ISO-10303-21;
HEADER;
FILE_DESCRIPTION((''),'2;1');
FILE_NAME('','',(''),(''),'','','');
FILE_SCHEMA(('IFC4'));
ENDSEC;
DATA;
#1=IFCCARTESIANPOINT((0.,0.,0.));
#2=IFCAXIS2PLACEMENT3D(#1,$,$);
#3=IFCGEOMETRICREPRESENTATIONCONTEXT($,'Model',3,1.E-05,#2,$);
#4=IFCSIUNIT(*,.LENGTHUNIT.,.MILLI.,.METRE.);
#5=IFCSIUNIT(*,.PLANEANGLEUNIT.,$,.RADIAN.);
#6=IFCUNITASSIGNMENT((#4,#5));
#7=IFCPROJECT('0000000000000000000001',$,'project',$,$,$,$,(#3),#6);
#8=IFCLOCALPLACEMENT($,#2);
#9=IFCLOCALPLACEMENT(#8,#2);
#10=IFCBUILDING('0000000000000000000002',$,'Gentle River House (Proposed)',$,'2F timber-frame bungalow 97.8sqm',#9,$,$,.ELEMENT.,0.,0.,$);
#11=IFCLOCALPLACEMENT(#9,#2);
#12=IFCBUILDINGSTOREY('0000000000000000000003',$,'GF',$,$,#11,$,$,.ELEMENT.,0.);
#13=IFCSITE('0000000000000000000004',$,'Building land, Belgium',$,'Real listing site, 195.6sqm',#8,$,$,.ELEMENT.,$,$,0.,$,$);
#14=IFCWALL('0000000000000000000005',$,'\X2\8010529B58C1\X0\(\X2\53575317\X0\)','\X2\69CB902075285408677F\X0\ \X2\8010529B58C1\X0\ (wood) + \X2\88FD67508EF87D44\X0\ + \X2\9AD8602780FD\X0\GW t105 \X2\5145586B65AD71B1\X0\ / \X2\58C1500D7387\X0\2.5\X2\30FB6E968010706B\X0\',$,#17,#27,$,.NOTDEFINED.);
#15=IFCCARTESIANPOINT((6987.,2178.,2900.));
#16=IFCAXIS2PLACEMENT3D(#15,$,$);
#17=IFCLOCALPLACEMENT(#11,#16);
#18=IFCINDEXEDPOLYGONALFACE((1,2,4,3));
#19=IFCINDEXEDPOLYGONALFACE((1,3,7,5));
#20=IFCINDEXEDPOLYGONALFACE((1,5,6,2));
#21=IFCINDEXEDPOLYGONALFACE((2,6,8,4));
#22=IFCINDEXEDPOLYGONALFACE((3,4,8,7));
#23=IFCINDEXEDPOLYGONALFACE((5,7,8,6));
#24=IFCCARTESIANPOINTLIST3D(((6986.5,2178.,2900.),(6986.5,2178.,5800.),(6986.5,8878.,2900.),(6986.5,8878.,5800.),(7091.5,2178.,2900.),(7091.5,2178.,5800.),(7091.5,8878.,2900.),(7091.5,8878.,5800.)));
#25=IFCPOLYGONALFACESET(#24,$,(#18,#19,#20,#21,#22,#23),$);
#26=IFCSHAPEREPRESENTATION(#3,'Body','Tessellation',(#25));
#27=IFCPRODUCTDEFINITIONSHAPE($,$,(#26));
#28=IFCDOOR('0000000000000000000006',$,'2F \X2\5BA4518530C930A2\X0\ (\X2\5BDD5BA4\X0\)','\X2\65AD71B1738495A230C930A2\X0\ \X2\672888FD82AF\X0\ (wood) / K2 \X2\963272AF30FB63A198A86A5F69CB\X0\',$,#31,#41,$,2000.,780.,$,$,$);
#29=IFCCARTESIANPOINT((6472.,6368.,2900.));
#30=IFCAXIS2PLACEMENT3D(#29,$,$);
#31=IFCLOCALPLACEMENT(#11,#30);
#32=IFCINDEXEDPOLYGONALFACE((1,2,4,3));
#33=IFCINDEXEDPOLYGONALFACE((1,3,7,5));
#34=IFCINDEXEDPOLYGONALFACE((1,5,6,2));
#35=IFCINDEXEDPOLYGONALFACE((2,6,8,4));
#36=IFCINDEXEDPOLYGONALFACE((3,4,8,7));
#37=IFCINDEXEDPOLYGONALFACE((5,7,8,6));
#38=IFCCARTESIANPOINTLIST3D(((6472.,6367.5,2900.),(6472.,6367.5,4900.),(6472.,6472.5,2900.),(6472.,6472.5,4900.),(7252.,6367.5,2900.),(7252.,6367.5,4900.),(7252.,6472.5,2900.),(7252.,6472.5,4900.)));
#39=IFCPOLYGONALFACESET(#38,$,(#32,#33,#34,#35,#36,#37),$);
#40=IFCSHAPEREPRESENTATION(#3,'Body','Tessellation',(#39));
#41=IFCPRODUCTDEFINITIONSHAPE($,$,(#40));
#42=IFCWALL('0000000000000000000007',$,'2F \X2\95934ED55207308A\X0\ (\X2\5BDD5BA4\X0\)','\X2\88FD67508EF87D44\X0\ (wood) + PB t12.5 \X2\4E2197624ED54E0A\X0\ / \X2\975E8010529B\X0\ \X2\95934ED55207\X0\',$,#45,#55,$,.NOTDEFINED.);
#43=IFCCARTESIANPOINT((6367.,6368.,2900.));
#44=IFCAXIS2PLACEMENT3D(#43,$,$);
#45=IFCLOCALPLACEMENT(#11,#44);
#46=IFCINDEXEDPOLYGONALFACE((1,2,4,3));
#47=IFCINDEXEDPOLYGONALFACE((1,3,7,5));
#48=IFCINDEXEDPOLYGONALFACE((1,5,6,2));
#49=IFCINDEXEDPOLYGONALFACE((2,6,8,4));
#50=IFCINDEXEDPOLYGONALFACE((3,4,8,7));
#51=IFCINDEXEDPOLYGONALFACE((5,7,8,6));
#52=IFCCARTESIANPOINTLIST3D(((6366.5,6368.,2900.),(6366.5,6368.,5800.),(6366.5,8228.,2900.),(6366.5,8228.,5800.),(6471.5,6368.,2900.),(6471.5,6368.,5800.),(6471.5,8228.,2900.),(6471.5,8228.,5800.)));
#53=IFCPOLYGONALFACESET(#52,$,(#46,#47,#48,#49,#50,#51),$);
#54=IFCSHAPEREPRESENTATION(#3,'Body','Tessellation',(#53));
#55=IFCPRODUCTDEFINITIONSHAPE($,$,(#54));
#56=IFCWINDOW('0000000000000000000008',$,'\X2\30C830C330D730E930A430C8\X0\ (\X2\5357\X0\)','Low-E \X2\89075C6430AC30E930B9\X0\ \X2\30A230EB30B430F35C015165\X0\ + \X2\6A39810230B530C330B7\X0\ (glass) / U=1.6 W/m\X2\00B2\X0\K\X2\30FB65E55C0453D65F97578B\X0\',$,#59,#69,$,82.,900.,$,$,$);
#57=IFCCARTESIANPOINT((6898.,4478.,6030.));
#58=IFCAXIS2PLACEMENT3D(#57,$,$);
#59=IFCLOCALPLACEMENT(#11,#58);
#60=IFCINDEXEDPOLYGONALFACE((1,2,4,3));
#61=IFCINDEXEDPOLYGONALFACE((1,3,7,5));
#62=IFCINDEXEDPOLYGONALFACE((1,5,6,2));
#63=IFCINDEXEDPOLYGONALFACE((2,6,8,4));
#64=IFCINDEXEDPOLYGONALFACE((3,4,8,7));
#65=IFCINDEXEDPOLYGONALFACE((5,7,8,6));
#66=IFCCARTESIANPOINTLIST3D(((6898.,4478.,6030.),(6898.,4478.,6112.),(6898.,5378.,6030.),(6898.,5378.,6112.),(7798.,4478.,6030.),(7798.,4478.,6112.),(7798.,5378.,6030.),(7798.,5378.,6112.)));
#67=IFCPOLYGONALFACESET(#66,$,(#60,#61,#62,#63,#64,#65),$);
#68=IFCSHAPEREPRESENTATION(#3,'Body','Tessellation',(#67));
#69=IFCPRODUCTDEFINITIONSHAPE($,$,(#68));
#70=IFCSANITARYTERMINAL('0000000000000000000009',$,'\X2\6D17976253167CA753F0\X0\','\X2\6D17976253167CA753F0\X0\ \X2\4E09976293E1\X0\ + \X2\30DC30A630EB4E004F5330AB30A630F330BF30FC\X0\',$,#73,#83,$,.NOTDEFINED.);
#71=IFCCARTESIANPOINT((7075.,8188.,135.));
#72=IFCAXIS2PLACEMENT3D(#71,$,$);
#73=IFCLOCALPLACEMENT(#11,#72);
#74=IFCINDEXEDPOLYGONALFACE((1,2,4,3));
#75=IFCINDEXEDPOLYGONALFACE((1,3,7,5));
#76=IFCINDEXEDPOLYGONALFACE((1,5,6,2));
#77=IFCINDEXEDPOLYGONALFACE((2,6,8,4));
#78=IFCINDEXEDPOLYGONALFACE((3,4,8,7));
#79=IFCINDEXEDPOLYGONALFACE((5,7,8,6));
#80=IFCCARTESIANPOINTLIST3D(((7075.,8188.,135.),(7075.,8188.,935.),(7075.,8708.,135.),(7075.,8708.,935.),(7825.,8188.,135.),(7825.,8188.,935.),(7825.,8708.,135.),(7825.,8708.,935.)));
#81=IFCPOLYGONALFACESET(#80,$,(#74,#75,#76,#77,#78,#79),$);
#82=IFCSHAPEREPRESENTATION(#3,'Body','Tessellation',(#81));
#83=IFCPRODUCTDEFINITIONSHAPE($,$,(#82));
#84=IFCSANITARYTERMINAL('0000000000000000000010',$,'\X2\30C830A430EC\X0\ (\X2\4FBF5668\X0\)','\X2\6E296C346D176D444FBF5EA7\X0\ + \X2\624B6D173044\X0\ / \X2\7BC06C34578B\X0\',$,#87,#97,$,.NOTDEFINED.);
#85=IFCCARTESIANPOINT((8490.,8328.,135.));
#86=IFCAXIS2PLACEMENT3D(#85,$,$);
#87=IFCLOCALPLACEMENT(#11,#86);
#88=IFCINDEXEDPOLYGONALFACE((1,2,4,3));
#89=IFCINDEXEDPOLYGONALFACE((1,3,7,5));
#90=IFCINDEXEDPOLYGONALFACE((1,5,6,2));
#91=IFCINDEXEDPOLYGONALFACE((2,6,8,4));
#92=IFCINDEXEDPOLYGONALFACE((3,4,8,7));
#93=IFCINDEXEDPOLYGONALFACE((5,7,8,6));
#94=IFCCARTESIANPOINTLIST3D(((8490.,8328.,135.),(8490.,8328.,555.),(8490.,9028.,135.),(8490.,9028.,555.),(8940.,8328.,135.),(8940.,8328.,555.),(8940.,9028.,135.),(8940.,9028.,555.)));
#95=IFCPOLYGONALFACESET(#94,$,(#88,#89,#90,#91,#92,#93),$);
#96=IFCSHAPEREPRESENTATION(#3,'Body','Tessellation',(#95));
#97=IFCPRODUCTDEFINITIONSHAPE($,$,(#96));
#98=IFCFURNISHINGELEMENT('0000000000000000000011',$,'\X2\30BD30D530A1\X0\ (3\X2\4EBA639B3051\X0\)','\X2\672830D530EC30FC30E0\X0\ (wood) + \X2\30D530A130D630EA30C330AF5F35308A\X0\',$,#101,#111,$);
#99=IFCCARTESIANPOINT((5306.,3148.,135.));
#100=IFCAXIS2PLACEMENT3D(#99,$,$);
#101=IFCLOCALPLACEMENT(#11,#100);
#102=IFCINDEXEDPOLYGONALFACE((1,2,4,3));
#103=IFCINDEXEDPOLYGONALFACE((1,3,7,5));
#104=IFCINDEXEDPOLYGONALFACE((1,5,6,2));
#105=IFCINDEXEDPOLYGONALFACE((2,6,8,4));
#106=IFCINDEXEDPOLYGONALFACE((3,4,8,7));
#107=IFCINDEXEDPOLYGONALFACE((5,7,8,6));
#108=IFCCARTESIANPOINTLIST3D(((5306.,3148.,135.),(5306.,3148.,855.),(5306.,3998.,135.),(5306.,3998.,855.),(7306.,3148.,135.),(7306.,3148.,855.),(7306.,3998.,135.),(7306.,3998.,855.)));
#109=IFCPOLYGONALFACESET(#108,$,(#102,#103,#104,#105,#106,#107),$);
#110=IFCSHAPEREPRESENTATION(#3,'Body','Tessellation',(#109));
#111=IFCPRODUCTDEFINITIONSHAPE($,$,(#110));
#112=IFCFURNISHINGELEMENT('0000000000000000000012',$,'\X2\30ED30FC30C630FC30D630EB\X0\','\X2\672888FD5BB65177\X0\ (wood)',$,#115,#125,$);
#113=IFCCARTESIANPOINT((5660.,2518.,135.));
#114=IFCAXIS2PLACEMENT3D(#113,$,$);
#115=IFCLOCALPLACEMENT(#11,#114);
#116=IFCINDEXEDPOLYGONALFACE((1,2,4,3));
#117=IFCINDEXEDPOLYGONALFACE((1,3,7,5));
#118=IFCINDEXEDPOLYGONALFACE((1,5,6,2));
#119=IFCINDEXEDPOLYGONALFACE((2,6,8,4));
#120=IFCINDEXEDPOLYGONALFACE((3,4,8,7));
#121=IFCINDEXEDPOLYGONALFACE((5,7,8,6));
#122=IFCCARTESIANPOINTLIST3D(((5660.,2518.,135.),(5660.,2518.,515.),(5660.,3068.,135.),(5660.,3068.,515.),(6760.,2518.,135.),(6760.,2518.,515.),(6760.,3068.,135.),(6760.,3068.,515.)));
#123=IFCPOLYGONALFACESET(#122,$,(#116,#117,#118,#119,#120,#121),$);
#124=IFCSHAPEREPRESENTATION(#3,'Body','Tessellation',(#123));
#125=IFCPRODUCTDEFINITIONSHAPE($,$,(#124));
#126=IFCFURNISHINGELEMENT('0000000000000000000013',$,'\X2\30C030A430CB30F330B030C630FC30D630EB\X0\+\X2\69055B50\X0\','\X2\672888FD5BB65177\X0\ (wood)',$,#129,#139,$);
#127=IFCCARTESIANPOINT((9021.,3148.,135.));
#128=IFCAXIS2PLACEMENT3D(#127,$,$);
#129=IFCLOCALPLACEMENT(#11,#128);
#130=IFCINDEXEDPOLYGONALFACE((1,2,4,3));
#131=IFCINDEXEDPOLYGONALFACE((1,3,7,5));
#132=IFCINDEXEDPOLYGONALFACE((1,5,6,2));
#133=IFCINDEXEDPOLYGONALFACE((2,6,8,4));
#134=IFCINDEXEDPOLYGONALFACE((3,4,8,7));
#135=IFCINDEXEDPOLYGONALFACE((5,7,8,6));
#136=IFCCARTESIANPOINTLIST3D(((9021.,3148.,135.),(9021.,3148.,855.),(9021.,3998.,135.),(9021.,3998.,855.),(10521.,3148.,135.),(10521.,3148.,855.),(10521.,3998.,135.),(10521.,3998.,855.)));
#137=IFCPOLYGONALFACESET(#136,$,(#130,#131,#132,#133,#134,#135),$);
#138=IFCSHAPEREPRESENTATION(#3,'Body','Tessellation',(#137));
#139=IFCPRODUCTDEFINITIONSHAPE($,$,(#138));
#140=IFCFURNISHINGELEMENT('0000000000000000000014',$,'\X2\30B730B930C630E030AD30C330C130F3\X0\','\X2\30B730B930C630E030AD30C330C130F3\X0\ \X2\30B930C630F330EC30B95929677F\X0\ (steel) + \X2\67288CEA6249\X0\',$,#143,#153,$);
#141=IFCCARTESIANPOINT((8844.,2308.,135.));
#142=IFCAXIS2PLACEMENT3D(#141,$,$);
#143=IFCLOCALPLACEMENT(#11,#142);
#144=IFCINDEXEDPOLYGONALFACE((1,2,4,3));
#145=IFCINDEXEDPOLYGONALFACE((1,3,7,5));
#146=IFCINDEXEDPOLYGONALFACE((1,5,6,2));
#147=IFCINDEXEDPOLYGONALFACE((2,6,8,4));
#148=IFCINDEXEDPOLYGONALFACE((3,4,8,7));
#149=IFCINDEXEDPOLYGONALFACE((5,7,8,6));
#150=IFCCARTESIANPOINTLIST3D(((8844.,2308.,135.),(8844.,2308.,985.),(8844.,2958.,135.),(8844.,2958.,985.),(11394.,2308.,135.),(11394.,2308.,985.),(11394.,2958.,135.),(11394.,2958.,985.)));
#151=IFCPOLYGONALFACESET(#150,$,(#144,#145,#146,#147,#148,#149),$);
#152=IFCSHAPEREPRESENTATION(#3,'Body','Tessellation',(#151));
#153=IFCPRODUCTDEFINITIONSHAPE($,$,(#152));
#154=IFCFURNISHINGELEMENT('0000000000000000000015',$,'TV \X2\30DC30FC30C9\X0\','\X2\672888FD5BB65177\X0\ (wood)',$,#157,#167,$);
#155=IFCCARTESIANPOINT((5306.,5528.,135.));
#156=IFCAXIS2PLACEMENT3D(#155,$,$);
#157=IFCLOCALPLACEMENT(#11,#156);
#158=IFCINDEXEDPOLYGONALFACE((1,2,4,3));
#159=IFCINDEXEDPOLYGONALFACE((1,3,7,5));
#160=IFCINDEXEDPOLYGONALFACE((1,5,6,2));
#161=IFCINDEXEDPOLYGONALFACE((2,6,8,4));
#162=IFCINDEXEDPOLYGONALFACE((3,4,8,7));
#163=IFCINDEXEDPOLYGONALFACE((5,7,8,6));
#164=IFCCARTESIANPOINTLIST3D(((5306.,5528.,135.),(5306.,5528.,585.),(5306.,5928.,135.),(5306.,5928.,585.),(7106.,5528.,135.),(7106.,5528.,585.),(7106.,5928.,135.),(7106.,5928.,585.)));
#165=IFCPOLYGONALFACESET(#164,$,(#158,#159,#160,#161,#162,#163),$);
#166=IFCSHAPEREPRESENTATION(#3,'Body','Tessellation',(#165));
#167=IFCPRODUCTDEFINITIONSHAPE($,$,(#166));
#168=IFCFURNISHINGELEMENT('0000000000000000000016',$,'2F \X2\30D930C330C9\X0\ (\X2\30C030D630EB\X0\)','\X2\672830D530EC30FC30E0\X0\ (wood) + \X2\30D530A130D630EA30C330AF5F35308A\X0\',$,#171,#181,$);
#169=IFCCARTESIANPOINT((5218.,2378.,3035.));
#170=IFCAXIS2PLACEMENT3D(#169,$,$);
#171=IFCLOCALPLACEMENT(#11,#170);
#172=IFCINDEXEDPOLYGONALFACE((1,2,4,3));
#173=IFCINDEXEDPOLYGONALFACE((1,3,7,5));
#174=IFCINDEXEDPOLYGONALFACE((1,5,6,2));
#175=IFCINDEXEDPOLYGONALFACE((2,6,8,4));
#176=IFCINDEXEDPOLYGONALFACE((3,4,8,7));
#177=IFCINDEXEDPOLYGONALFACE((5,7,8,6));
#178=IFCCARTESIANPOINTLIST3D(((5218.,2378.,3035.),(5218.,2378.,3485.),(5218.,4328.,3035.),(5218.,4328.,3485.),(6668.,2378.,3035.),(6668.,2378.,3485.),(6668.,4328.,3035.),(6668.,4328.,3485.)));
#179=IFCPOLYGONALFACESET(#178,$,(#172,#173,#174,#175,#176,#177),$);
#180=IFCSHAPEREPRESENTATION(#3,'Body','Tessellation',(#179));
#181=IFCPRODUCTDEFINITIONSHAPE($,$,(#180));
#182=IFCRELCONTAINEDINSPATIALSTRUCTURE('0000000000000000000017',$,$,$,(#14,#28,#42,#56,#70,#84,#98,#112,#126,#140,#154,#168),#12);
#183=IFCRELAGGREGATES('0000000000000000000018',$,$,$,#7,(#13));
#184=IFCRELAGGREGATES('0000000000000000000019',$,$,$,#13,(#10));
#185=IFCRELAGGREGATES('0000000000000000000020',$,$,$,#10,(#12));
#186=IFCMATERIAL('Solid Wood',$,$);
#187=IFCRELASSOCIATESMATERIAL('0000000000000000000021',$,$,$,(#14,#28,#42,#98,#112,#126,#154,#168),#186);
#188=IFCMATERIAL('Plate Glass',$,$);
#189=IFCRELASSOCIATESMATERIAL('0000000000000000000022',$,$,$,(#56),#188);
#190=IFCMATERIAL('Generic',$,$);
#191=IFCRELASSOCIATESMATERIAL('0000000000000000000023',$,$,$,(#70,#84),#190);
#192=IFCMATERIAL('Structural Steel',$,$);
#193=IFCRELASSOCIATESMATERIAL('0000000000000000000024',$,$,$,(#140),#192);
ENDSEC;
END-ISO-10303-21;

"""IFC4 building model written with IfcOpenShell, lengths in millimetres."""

from ifc_helpers import new_model, si_unit, frame, frame_2d, origin, place, context, project, spatial, rectangle, extrude, material, element, fill, save


model = new_model("IFC4")

# Units and contexts
model_context = context("Model", 3, precision=1e-05, world=origin())
ifc_project = project(units=[si_unit("LENGTHUNIT", "METRE", prefix="MILLI"), si_unit("PLANEANGLEUNIT", "RADIAN")], contexts=[model_context])

# Site, building, storey
site_placement = place(None, origin())
site = spatial("IfcSite", under=ifc_project, at=site_placement, Name="Building land, Belgium", ObjectType="Real listing site, 195.6sqm", CompositionType="ELEMENT", RefElevation=0.0)
building_placement = place(site_placement, origin())
building = spatial("IfcBuilding", under=site, at=building_placement, Name="Gentle River House (Proposed)", ObjectType="2F timber-frame bungalow 97.8sqm", CompositionType="ELEMENT", ElevationOfRefHeight=0.0, ElevationOfTerrain=0.0)
storey_placement = place(building_placement, origin())
storey = spatial("IfcBuildingStorey", under=building, at=storey_placement, Name="GF", CompositionType="ELEMENT", Elevation=0.0)

# Shared definitions
ifc_material_1 = material(Name="Solid Wood")

# Wall, opening, door
wall_1_placement = place(storey_placement, frame((6987.0, 2178.0, 2900.0)))
wall_1 = element("IfcWall", 1, at=wall_1_placement, inside=storey, material=ifc_material_1, Name="耐力壁(南北)", Description="構造用合板 耐力壁 (wood) + 製材軸組 + 高性能GW t105 充填断熱 / 壁倍率2.5・準耐火", PredefinedType="NOTDEFINED", context=model_context, shape_type="SweptSolid", body=[
    extrude(rectangle(XDim=105.0, YDim=6700.0, at=frame_2d((52.0, 3350.0))), frame((6987.0, 2178.0, 2900.0)), (0.0, 0.0, 1.0), 2900.0),
])
opening_1_placement = place(storey_placement, frame((6472.0, 6368.0, 2900.0)))
opening_1 = element("IfcOpeningElement", 2, at=opening_1_placement, cuts=wall_1, PredefinedType="NOTDEFINED", context=model_context, shape_type="SweptSolid", body=[
    extrude(rectangle(XDim=780.0, YDim=105.0, at=frame_2d((390.0, 52.0))), frame((6472.0, 6368.0, 2900.0)), (0.0, 0.0, 1.0), 2000.0),
])
door_1_placement = place(storey_placement, frame((6472.0, 6368.0, 2900.0)))
door_1 = element("IfcDoor", 3, at=door_1_placement, inside=storey, material=ifc_material_1, Name="2F 室内ドア (寝室)", Description="断熱玄関ドア 木製芯 (wood) / K2 防犯・採風機構", OverallHeight=2000.0, OverallWidth=780.0, context=model_context, shape_type="SweptSolid", body=[
    extrude(rectangle(XDim=780.0, YDim=105.0, at=frame_2d((390.0, 52.0))), frame((6472.0, 6368.0, 2900.0)), (0.0, 0.0, 1.0), 2000.0),
])
fill(opening_1, door_1)

# Wall
wall_2_placement = place(storey_placement, frame((6367.0, 6368.0, 2900.0)))
element("IfcWall", 4, at=wall_2_placement, inside=storey, material=ifc_material_1, Name="2F 間仕切り (寝室)", Description="製材軸組 (wood) + PB t12.5 両面仕上 / 非耐力 間仕切", PredefinedType="NOTDEFINED", context=model_context, shape_type="SweptSolid", body=[
    extrude(rectangle(XDim=105.0, YDim=1860.0, at=frame_2d((52.0, 930.0))), frame((6367.0, 6368.0, 2900.0)), (0.0, 0.0, 1.0), 2900.0),
])

# Window
ifc_material_2 = material(Name="Plate Glass")
window_placement = place(storey_placement, frame((6898.0, 4478.0, 6030.0)))
element("IfcWindow", 5, at=window_placement, inside=storey, material=ifc_material_2, Name="トップライト (南)", Description="Low-E 複層ガラス アルゴン封入 + 樹脂サッシ (glass) / U=1.6 W/m²K・日射取得型", OverallHeight=82.0, OverallWidth=900.0, context=model_context, shape_type="SweptSolid", body=[
    extrude(rectangle(XDim=900.0, YDim=900.0, at=frame_2d((450.0, 450.0))), frame((6898.0, 4478.0, 6030.0)), (0.0, 0.0, 1.0), 82.0),
])

# Sanitary terminals
ifc_material_3 = material(Name="Generic")
sanitary_terminal_1_placement = place(storey_placement, frame((7075.0, 8188.0, 135.0)))
element("IfcSanitaryTerminal", 6, at=sanitary_terminal_1_placement, inside=storey, material=ifc_material_3, Name="洗面化粧台", Description="洗面化粧台 三面鏡 + ボウル一体カウンター", PredefinedType="NOTDEFINED", context=model_context, shape_type="SweptSolid", body=[
    extrude(rectangle(XDim=750.0, YDim=520.0, at=frame_2d((375.0, 260.0))), frame((7075.0, 8188.0, 135.0)), (0.0, 0.0, 1.0), 800.0),
])
sanitary_terminal_2_placement = place(storey_placement, frame((8490.0, 8328.0, 135.0)))
element("IfcSanitaryTerminal", 7, at=sanitary_terminal_2_placement, inside=storey, material=ifc_material_3, Name="トイレ (便器)", Description="温水洗浄便座 + 手洗い / 節水型", PredefinedType="NOTDEFINED", context=model_context, shape_type="SweptSolid", body=[
    extrude(rectangle(XDim=450.0, YDim=700.0, at=frame_2d((225.0, 350.0))), frame((8490.0, 8328.0, 135.0)), (0.0, 0.0, 1.0), 420.0),
])

# Furnishing elements
furnishing_1_placement = place(storey_placement, frame((5306.0, 3148.0, 135.0)))
element("IfcFurnishingElement", 8, at=furnishing_1_placement, inside=storey, material=ifc_material_1, Name="ソファ (3人掛け)", Description="木フレーム (wood) + ファブリック張り", context=model_context, shape_type="SweptSolid", body=[
    extrude(rectangle(XDim=2000.0, YDim=850.0, at=frame_2d((1000.0, 425.0))), frame((5306.0, 3148.0, 135.0)), (0.0, 0.0, 1.0), 720.0),
])
furnishing_2_placement = place(storey_placement, frame((5660.0, 2518.0, 135.0)))
element("IfcFurnishingElement", 9, at=furnishing_2_placement, inside=storey, material=ifc_material_1, Name="ローテーブル", Description="木製家具 (wood)", context=model_context, shape_type="SweptSolid", body=[
    extrude(rectangle(XDim=1100.0, YDim=550.0, at=frame_2d((550.0, 275.0))), frame((5660.0, 2518.0, 135.0)), (0.0, 0.0, 1.0), 380.0),
])
furnishing_3_placement = place(storey_placement, frame((9021.0, 3148.0, 135.0)))
element("IfcFurnishingElement", 10, at=furnishing_3_placement, inside=storey, material=ifc_material_1, Name="ダイニングテーブル+椅子", Description="木製家具 (wood)", context=model_context, shape_type="SweptSolid", body=[
    extrude(rectangle(XDim=1500.0, YDim=850.0, at=frame_2d((750.0, 425.0))), frame((9021.0, 3148.0, 135.0)), (0.0, 0.0, 1.0), 720.0),
])
ifc_material_4 = material(Name="Structural Steel")
furnishing_4_placement = place(storey_placement, frame((8844.0, 2308.0, 135.0)))
element("IfcFurnishingElement", 11, at=furnishing_4_placement, inside=storey, material=ifc_material_4, Name="システムキッチン", Description="システムキッチン ステンレス天板 (steel) + 木質扉", context=model_context, shape_type="SweptSolid", body=[
    extrude(rectangle(XDim=2550.0, YDim=650.0, at=frame_2d((1275.0, 325.0))), frame((8844.0, 2308.0, 135.0)), (0.0, 0.0, 1.0), 850.0),
])
furnishing_5_placement = place(storey_placement, frame((5306.0, 5528.0, 135.0)))
element("IfcFurnishingElement", 12, at=furnishing_5_placement, inside=storey, material=ifc_material_1, Name="TV ボード", Description="木製家具 (wood)", context=model_context, shape_type="SweptSolid", body=[
    extrude(rectangle(XDim=1800.0, YDim=400.0, at=frame_2d((900.0, 200.0))), frame((5306.0, 5528.0, 135.0)), (0.0, 0.0, 1.0), 450.0),
])
furnishing_6_placement = place(storey_placement, frame((5218.0, 2378.0, 3035.0)))
element("IfcFurnishingElement", 13, at=furnishing_6_placement, inside=storey, material=ifc_material_1, Name="2F ベッド (ダブル)", Description="木フレーム (wood) + ファブリック張り", context=model_context, shape_type="SweptSolid", body=[
    extrude(rectangle(XDim=1450.0, YDim=1950.0, at=frame_2d((725.0, 975.0))), frame((5218.0, 2378.0, 3035.0)), (0.0, 0.0, 1.0), 450.0),
])

save(model, "model.ifc")
